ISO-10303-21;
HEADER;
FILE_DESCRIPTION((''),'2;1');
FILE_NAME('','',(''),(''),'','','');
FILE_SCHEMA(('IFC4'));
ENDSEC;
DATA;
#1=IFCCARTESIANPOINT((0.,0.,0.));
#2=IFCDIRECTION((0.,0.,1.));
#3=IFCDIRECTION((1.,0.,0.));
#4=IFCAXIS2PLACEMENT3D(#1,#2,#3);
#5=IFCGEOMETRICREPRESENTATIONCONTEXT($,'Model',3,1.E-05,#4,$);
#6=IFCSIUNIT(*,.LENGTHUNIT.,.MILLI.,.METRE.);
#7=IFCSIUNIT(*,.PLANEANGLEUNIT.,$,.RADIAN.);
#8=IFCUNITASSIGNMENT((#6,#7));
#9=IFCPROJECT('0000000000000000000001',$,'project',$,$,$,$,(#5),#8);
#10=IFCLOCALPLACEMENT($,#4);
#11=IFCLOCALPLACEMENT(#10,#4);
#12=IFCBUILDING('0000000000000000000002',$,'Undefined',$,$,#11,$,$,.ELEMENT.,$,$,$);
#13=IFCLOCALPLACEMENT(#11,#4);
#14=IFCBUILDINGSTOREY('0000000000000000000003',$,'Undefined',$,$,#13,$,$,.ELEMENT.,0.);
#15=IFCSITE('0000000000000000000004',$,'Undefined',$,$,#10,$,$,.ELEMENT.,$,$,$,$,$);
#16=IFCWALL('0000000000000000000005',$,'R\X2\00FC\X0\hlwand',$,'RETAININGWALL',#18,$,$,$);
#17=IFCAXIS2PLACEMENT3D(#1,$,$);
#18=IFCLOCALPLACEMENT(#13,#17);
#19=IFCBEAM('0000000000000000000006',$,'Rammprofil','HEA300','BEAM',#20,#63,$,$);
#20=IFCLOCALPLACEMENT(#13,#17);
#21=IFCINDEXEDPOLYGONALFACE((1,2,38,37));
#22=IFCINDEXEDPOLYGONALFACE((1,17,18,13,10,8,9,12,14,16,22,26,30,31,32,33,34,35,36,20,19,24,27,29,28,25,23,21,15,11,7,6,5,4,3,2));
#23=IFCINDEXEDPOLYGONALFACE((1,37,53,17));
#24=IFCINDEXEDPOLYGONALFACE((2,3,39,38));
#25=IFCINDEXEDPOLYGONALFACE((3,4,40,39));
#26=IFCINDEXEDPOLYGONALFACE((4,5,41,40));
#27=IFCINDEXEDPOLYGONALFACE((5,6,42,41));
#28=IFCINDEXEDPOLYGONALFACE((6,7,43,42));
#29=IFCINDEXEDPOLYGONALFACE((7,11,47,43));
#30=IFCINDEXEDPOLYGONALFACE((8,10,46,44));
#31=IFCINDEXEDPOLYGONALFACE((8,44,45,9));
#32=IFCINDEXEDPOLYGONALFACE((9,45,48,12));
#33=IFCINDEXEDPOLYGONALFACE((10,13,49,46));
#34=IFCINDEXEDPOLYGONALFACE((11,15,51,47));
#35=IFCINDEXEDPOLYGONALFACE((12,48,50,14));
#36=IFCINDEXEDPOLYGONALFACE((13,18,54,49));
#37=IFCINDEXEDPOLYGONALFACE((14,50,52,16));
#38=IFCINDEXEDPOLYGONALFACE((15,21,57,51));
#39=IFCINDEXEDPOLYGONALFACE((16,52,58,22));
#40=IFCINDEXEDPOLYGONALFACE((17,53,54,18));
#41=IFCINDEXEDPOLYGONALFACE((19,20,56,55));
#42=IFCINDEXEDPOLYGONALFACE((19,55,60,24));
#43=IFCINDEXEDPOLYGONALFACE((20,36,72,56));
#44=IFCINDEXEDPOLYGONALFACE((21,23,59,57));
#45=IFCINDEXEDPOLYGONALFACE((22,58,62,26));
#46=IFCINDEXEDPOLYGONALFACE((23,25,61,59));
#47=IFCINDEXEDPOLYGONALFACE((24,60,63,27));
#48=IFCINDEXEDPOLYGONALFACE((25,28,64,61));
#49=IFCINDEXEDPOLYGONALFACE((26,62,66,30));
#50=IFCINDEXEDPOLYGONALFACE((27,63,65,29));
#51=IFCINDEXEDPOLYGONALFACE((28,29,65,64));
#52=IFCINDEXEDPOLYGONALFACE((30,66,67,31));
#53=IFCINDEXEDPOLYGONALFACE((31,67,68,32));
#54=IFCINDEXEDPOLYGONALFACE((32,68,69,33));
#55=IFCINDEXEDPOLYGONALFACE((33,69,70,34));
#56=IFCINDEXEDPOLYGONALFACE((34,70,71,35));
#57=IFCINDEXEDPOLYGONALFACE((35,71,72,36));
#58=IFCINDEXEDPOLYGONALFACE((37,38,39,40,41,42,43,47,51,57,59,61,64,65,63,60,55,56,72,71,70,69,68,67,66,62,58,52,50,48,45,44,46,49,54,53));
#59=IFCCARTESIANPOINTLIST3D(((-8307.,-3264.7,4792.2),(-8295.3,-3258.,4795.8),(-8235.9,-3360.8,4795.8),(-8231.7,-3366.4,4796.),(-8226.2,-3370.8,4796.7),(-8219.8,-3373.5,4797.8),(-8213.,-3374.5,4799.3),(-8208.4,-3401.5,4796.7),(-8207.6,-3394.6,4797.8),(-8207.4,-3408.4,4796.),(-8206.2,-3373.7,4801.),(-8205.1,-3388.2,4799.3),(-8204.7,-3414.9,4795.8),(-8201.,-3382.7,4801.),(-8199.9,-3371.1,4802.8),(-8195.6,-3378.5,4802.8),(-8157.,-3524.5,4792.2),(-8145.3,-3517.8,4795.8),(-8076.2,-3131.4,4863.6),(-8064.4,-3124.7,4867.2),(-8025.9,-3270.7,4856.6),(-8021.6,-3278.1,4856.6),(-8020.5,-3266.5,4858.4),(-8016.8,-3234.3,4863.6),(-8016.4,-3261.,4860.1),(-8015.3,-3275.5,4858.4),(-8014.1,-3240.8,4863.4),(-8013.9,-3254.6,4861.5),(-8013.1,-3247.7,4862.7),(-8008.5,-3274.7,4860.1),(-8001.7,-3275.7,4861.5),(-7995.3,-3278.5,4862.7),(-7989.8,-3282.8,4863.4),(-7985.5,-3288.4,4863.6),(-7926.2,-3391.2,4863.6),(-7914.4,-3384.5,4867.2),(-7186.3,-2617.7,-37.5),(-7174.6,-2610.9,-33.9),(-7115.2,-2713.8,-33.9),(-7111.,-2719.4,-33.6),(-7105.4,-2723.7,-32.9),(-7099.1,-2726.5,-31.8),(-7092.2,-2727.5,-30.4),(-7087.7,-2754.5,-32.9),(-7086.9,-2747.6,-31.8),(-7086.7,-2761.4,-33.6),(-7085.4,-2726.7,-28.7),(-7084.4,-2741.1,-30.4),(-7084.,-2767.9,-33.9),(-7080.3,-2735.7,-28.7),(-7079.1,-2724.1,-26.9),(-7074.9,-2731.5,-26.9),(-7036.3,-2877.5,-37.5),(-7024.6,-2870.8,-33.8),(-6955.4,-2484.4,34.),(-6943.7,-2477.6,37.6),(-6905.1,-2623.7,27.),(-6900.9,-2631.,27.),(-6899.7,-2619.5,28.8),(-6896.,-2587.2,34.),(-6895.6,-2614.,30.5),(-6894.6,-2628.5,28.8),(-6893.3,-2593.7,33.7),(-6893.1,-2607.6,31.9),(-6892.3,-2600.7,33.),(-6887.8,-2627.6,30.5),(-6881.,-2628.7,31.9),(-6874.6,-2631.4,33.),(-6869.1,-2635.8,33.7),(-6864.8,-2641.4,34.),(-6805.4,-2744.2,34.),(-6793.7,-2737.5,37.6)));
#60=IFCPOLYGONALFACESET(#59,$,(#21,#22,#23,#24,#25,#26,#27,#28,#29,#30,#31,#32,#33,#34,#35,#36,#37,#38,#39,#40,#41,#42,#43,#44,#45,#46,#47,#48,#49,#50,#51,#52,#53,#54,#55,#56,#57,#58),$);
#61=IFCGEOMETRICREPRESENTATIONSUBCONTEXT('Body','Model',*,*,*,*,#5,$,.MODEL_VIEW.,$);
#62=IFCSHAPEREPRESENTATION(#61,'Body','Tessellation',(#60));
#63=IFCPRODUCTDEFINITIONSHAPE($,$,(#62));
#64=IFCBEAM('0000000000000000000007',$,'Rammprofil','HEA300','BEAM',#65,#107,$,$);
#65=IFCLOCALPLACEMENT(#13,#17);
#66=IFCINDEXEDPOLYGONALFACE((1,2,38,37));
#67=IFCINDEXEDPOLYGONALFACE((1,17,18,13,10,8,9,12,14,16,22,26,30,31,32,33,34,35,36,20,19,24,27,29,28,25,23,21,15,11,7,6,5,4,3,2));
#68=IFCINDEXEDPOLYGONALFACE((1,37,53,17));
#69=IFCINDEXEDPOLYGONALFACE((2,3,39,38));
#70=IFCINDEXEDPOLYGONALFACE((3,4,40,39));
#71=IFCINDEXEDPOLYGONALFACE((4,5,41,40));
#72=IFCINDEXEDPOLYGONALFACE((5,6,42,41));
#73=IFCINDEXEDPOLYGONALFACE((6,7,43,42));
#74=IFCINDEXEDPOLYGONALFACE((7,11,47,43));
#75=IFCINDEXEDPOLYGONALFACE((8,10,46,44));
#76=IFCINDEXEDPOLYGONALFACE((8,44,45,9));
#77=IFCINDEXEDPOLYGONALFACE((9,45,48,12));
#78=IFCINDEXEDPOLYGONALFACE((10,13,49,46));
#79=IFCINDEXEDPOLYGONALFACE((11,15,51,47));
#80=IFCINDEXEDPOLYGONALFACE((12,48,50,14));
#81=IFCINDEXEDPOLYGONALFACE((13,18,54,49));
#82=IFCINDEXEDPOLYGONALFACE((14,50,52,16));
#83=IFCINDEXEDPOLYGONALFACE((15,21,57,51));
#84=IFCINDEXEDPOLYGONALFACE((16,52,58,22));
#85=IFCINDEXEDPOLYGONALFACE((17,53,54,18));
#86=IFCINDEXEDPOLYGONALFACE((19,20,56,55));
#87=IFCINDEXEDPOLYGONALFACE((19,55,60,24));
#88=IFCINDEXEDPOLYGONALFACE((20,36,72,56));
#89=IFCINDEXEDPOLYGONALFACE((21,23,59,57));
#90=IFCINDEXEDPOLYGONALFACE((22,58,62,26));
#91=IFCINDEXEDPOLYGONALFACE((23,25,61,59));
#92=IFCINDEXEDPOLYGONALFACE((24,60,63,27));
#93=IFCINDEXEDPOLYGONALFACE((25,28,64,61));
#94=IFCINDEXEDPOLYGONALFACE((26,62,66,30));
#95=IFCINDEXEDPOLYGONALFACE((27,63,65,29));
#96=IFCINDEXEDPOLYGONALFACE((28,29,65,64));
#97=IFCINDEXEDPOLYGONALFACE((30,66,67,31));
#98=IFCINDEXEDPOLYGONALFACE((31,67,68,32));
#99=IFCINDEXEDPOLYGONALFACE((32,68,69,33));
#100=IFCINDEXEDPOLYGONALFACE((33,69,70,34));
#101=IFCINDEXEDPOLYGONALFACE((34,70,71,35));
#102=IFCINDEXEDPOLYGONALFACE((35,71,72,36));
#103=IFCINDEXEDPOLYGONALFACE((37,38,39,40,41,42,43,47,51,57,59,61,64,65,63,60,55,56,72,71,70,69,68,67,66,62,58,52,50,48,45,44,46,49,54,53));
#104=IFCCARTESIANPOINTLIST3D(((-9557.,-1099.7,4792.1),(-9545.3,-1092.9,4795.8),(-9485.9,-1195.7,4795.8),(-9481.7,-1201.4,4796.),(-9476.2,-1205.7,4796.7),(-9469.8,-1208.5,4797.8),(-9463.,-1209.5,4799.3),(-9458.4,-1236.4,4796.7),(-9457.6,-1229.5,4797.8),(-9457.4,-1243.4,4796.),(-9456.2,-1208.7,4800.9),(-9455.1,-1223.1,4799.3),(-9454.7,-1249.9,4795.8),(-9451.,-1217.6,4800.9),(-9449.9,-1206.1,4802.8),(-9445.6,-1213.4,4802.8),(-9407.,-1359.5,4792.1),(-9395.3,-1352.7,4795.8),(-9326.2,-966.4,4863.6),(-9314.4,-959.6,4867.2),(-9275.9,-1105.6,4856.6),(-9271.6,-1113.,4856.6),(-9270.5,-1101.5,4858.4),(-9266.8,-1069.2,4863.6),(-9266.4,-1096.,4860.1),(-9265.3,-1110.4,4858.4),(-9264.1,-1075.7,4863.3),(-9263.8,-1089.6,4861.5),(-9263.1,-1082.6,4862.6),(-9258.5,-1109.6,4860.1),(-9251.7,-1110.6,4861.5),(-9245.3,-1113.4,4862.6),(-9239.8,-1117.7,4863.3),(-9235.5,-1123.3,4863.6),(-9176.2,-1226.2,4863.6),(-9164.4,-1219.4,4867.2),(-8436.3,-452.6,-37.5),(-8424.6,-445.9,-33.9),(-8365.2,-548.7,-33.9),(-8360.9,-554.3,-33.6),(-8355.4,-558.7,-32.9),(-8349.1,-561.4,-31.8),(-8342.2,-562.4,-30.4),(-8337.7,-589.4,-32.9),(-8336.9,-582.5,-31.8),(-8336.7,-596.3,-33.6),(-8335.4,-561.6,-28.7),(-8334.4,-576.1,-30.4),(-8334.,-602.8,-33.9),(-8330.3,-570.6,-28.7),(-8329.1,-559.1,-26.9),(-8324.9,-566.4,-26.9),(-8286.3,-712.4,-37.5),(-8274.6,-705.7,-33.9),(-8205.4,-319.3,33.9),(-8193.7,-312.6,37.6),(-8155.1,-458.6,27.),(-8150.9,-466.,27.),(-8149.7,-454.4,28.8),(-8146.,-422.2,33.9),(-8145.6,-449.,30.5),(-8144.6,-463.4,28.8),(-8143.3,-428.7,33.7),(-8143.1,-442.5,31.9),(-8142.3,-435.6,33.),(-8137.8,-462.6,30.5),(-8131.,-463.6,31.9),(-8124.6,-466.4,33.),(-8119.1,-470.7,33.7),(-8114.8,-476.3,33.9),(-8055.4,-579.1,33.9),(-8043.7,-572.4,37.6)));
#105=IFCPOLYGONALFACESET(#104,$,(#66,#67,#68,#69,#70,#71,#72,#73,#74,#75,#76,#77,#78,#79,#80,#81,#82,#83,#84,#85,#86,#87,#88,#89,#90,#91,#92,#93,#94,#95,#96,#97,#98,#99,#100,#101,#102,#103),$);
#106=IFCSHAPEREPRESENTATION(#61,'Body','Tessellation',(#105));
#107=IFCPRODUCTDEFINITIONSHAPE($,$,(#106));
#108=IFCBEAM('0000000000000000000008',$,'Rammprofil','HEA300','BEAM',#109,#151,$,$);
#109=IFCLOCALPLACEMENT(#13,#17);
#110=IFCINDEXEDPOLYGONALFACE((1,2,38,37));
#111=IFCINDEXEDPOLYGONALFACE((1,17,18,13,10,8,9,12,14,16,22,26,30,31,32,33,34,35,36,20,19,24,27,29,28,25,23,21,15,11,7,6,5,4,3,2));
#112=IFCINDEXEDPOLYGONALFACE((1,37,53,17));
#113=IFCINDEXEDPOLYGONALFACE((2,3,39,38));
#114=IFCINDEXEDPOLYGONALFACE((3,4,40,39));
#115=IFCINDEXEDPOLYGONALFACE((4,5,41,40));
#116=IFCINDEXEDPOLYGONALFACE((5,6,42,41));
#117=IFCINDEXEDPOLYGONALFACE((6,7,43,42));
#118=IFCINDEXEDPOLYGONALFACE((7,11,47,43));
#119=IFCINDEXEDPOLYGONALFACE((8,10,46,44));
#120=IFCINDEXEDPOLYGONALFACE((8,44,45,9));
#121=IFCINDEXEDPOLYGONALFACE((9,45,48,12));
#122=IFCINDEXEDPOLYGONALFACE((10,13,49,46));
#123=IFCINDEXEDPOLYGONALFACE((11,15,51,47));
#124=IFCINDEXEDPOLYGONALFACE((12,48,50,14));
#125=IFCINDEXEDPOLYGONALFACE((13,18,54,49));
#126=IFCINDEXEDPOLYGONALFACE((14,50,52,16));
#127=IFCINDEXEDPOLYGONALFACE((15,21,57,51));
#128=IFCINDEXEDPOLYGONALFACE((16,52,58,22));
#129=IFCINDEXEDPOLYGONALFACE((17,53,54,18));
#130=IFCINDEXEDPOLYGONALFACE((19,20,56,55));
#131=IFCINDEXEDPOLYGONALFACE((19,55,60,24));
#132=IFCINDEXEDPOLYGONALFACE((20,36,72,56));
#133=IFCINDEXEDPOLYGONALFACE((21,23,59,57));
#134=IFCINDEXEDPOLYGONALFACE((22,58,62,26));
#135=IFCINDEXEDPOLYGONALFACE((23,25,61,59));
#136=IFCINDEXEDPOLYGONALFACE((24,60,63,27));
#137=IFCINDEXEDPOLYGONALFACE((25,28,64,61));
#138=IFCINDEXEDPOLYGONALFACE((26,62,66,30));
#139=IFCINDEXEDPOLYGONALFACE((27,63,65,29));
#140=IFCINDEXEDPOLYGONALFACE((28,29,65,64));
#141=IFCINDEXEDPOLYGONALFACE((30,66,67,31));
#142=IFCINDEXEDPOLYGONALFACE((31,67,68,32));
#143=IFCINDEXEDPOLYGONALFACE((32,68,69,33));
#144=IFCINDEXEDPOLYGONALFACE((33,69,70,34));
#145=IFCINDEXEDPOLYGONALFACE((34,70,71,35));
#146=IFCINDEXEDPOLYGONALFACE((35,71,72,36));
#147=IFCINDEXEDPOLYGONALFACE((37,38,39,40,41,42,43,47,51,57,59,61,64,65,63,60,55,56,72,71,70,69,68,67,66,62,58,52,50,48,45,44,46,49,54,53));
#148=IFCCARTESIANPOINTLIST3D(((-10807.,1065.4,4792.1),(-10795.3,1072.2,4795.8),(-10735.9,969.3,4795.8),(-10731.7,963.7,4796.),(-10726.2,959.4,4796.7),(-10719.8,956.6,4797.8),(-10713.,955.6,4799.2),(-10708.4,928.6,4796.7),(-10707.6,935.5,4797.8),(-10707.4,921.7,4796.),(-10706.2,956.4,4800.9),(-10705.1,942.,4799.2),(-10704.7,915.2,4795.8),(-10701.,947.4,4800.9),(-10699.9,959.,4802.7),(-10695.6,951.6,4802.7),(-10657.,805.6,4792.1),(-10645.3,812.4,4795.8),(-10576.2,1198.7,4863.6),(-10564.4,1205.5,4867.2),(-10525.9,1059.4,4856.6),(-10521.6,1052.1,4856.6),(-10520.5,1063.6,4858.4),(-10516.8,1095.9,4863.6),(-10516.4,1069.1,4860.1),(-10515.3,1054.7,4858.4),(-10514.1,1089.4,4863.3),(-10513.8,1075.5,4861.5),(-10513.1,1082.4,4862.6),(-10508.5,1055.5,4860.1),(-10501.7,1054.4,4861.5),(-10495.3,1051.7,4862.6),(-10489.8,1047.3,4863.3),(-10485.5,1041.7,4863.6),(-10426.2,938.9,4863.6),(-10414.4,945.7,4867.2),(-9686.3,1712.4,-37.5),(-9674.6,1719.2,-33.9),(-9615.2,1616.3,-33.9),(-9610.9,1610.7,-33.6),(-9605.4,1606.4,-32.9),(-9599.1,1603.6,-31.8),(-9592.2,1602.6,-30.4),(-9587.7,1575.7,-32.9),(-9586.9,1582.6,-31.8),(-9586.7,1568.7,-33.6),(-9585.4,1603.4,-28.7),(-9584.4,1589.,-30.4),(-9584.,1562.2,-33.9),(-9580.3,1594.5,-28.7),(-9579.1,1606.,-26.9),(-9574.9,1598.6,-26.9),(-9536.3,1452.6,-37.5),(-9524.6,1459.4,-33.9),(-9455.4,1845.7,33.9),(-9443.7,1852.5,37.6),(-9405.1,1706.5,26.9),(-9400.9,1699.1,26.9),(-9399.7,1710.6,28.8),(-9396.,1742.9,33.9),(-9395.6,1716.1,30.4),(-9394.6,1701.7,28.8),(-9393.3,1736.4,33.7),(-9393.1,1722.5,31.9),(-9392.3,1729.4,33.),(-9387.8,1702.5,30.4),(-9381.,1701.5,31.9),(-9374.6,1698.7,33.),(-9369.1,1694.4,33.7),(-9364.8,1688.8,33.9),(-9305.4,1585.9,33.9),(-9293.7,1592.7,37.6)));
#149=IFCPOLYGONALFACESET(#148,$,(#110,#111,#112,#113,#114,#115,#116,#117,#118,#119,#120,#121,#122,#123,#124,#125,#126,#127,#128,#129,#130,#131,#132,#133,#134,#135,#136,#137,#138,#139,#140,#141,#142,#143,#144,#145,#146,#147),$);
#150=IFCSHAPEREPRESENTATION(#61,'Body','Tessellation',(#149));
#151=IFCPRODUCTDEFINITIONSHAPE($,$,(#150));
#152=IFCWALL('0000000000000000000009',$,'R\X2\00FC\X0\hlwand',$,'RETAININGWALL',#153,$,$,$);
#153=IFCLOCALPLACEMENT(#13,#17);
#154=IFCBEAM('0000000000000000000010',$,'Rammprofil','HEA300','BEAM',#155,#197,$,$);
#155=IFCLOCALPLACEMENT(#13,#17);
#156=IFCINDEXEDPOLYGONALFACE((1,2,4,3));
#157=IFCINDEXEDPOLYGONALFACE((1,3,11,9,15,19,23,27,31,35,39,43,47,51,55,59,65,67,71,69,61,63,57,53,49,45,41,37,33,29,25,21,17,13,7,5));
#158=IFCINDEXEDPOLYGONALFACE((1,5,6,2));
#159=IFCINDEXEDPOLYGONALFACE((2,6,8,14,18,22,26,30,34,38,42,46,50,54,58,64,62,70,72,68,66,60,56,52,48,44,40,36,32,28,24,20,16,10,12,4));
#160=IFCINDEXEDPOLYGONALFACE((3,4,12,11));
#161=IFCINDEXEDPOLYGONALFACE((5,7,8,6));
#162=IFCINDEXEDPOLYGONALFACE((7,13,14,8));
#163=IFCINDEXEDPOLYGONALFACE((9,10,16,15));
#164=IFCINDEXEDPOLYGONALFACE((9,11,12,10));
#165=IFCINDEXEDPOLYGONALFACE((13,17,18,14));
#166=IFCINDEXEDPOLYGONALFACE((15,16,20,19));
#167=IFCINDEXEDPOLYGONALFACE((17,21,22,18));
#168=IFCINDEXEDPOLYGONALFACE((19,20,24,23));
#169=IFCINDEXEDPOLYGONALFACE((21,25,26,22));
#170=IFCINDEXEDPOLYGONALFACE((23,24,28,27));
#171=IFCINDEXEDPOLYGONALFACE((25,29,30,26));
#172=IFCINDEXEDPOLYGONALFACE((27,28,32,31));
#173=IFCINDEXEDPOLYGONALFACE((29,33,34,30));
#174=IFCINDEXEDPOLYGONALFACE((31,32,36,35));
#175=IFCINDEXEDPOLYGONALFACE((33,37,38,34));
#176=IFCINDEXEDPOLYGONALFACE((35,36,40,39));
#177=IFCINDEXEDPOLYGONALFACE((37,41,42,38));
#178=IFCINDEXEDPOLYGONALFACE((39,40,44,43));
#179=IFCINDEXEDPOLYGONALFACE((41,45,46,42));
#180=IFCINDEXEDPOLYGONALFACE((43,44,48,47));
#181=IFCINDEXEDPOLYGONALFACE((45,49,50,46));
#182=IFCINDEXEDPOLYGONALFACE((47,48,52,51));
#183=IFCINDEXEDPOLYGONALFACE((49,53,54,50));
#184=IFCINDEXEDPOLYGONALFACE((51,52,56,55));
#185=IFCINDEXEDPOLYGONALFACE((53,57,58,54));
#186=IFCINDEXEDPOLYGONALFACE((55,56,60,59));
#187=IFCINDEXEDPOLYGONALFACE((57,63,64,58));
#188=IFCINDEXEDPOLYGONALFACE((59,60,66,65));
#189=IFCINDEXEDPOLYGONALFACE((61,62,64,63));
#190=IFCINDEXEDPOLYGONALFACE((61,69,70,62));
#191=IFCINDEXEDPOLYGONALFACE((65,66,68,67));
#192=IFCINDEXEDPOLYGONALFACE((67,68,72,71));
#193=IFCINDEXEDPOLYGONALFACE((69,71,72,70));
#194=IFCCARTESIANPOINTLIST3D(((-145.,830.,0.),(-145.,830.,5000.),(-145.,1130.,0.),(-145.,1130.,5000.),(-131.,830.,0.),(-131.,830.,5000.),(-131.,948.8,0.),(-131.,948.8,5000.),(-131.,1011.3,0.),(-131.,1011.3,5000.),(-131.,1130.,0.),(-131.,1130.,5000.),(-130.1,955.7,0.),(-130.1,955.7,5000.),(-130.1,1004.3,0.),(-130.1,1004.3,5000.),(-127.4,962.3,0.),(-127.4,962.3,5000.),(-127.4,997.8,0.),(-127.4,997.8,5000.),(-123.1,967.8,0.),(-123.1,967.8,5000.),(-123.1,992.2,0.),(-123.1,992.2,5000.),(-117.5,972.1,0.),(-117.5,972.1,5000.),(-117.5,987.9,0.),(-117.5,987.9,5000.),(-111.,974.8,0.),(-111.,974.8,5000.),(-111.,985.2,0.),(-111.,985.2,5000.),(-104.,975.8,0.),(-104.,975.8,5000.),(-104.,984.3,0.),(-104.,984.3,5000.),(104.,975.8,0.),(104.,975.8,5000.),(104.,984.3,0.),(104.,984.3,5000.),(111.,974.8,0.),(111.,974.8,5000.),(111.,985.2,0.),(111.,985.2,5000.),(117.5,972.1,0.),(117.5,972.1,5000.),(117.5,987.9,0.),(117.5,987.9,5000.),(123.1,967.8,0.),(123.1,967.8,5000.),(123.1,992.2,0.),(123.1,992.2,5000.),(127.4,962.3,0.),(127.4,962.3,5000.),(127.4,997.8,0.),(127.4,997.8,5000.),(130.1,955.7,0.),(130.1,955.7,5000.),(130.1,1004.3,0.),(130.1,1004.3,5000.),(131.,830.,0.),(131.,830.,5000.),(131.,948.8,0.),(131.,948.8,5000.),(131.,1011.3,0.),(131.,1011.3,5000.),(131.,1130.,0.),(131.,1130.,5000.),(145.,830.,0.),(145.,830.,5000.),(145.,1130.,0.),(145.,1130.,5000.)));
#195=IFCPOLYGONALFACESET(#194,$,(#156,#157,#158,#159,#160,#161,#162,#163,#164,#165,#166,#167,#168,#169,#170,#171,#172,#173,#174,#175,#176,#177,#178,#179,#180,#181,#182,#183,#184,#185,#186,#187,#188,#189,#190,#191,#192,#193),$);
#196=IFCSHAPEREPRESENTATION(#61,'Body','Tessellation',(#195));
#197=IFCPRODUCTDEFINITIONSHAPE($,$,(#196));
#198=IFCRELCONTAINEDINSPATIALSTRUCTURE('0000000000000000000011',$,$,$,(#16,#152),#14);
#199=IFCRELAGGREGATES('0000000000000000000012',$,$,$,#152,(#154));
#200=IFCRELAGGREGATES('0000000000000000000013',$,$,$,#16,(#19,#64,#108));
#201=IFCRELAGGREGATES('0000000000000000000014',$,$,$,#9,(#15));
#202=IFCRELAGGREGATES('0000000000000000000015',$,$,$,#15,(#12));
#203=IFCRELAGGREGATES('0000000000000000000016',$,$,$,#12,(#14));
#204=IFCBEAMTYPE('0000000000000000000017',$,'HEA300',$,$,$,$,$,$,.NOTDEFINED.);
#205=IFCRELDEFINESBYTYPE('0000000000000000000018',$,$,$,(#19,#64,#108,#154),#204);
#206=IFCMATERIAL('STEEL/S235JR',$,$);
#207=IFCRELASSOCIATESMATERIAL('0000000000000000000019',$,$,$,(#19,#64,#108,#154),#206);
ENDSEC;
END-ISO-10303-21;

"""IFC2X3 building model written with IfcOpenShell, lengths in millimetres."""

from ifc_helpers import new_model, si_unit, frame, origin_with_axes, origin_2d_with_axis, place, context, subcontext, project, spatial, i_section, extrude, material, type_object, element, aggregate, save


model = new_model("IFC2X3")

# Units and contexts
model_context = context("Model", 3, precision=1e-05, world=origin_with_axes())
body_context = subcontext(model_context, "Body", "Model", "MODEL_VIEW")
ifc_project = project(units=[si_unit("LENGTHUNIT", "METRE", prefix="MILLI"), si_unit("PLANEANGLEUNIT", "RADIAN")], contexts=[model_context])

# Site, building, storey
site_placement = place(None, origin_with_axes())
site = spatial("IfcSite", under=ifc_project, at=site_placement, Name="Undefined", CompositionType="ELEMENT")
building_placement = place(site_placement, origin_with_axes())
building = spatial("IfcBuilding", under=site, at=building_placement, Name="Undefined", CompositionType="ELEMENT")
storey_placement = place(building_placement, origin_with_axes())
storey = spatial("IfcBuildingStorey", under=building, at=storey_placement, Name="Undefined", CompositionType="ELEMENT", Elevation=0.0)

# Wall, beams
wall_1_placement = place(storey_placement, origin_with_axes())
wall_1 = element("IfcWall", 1, at=wall_1_placement, inside=storey, Name="Rühlwand", ObjectType="RETAININGWALL")
ifc_material_1 = material(Name="STEEL/S235JR")
beam_type_1 = type_object("IfcBeamType", Name="HEA300", PredefinedType="NOTDEFINED")
beam_1_placement = place(wall_1_placement, frame((-6990.0, -2677.6, 0.1), z_axis=(-0.836516, -0.482964, -0.258819), x_axis=(-0.224147, -0.129405, 0.965926)))
beam_1 = element("IfcBeam", 2, at=beam_1_placement, type_object=beam_type_1, material=ifc_material_1, Name="Rammprofil", Description="HEA300", ObjectType="BEAM", context=body_context, shape_type="SweptSolid", body=[
    extrude(i_section(OverallWidth=300.0, OverallDepth=290.0, WebThickness=8.5, FlangeThickness=14.0, FilletRadius=27.0, at=origin_2d_with_axis()), frame((5000.0, 0.0, 0.0), z_axis=(-1.0, 0.0, 0.0), x_axis=(0.0, -1.0, 0.0)), (0.0, 0.0, 1.0), 5000.0),
])
beam_2_placement = place(wall_1_placement, frame((-8240.0, -512.5, 0.0), z_axis=(-0.836516, -0.482964, -0.258819), x_axis=(-0.224147, -0.129405, 0.965926)))
beam_2 = element("IfcBeam", 3, at=beam_2_placement, type_object=beam_type_1, material=ifc_material_1, Name="Rammprofil", Description="HEA300", ObjectType="BEAM", context=body_context, shape_type="SweptSolid", body=[
    extrude(i_section(OverallWidth=300.0, OverallDepth=290.0, WebThickness=8.5, FlangeThickness=14.0, FilletRadius=27.0, at=origin_2d_with_axis()), frame((5000.0, 0.0, 0.0), z_axis=(-1.0, 0.0, 0.0), x_axis=(0.0, -1.0, 0.0)), (0.0, 0.0, 1.0), 5000.0),
])
beam_3_placement = place(wall_1_placement, frame((-9490.0, 1652.6, 0.0), z_axis=(-0.836516, -0.482964, -0.258819), x_axis=(-0.224147, -0.129405, 0.965926)))
beam_3 = element("IfcBeam", 4, at=beam_3_placement, type_object=beam_type_1, material=ifc_material_1, Name="Rammprofil", Description="HEA300", ObjectType="BEAM", context=body_context, shape_type="SweptSolid", body=[
    extrude(i_section(OverallWidth=300.0, OverallDepth=290.0, WebThickness=8.5, FlangeThickness=14.0, FilletRadius=27.0, at=origin_2d_with_axis()), frame((5000.0, 0.0, 0.0), z_axis=(-1.0, 0.0, 0.0), x_axis=(0.0, -1.0, 0.0)), (0.0, 0.0, 1.0), 5000.0),
])

# Wall, beam
wall_2_placement = place(storey_placement, origin_with_axes())
wall_2 = element("IfcWall", 5, at=wall_2_placement, inside=storey, Name="Rühlwand", ObjectType="RETAININGWALL")
beam_4_placement = place(wall_2_placement, frame((0.0, 980.0, 0.0), z_axis=(-1.0, 0.0, 0.0), x_axis=(0.0, 0.0, 1.0)))
beam_4 = element("IfcBeam", 6, at=beam_4_placement, type_object=beam_type_1, material=ifc_material_1, Name="Rammprofil", Description="HEA300", ObjectType="BEAM", context=body_context, shape_type="SweptSolid", body=[
    extrude(i_section(OverallWidth=300.0, OverallDepth=290.0, WebThickness=8.5, FlangeThickness=14.0, FilletRadius=27.0, at=origin_2d_with_axis()), frame((5000.0, 0.0, 0.0), z_axis=(-1.0, 0.0, 0.0), x_axis=(0.0, -1.0, 0.0)), (0.0, 0.0, 1.0), 5000.0),
])
aggregate(wall_2, [beam_4])

aggregate(wall_1, [beam_1, beam_2, beam_3])

save(model, "model.ifc")
